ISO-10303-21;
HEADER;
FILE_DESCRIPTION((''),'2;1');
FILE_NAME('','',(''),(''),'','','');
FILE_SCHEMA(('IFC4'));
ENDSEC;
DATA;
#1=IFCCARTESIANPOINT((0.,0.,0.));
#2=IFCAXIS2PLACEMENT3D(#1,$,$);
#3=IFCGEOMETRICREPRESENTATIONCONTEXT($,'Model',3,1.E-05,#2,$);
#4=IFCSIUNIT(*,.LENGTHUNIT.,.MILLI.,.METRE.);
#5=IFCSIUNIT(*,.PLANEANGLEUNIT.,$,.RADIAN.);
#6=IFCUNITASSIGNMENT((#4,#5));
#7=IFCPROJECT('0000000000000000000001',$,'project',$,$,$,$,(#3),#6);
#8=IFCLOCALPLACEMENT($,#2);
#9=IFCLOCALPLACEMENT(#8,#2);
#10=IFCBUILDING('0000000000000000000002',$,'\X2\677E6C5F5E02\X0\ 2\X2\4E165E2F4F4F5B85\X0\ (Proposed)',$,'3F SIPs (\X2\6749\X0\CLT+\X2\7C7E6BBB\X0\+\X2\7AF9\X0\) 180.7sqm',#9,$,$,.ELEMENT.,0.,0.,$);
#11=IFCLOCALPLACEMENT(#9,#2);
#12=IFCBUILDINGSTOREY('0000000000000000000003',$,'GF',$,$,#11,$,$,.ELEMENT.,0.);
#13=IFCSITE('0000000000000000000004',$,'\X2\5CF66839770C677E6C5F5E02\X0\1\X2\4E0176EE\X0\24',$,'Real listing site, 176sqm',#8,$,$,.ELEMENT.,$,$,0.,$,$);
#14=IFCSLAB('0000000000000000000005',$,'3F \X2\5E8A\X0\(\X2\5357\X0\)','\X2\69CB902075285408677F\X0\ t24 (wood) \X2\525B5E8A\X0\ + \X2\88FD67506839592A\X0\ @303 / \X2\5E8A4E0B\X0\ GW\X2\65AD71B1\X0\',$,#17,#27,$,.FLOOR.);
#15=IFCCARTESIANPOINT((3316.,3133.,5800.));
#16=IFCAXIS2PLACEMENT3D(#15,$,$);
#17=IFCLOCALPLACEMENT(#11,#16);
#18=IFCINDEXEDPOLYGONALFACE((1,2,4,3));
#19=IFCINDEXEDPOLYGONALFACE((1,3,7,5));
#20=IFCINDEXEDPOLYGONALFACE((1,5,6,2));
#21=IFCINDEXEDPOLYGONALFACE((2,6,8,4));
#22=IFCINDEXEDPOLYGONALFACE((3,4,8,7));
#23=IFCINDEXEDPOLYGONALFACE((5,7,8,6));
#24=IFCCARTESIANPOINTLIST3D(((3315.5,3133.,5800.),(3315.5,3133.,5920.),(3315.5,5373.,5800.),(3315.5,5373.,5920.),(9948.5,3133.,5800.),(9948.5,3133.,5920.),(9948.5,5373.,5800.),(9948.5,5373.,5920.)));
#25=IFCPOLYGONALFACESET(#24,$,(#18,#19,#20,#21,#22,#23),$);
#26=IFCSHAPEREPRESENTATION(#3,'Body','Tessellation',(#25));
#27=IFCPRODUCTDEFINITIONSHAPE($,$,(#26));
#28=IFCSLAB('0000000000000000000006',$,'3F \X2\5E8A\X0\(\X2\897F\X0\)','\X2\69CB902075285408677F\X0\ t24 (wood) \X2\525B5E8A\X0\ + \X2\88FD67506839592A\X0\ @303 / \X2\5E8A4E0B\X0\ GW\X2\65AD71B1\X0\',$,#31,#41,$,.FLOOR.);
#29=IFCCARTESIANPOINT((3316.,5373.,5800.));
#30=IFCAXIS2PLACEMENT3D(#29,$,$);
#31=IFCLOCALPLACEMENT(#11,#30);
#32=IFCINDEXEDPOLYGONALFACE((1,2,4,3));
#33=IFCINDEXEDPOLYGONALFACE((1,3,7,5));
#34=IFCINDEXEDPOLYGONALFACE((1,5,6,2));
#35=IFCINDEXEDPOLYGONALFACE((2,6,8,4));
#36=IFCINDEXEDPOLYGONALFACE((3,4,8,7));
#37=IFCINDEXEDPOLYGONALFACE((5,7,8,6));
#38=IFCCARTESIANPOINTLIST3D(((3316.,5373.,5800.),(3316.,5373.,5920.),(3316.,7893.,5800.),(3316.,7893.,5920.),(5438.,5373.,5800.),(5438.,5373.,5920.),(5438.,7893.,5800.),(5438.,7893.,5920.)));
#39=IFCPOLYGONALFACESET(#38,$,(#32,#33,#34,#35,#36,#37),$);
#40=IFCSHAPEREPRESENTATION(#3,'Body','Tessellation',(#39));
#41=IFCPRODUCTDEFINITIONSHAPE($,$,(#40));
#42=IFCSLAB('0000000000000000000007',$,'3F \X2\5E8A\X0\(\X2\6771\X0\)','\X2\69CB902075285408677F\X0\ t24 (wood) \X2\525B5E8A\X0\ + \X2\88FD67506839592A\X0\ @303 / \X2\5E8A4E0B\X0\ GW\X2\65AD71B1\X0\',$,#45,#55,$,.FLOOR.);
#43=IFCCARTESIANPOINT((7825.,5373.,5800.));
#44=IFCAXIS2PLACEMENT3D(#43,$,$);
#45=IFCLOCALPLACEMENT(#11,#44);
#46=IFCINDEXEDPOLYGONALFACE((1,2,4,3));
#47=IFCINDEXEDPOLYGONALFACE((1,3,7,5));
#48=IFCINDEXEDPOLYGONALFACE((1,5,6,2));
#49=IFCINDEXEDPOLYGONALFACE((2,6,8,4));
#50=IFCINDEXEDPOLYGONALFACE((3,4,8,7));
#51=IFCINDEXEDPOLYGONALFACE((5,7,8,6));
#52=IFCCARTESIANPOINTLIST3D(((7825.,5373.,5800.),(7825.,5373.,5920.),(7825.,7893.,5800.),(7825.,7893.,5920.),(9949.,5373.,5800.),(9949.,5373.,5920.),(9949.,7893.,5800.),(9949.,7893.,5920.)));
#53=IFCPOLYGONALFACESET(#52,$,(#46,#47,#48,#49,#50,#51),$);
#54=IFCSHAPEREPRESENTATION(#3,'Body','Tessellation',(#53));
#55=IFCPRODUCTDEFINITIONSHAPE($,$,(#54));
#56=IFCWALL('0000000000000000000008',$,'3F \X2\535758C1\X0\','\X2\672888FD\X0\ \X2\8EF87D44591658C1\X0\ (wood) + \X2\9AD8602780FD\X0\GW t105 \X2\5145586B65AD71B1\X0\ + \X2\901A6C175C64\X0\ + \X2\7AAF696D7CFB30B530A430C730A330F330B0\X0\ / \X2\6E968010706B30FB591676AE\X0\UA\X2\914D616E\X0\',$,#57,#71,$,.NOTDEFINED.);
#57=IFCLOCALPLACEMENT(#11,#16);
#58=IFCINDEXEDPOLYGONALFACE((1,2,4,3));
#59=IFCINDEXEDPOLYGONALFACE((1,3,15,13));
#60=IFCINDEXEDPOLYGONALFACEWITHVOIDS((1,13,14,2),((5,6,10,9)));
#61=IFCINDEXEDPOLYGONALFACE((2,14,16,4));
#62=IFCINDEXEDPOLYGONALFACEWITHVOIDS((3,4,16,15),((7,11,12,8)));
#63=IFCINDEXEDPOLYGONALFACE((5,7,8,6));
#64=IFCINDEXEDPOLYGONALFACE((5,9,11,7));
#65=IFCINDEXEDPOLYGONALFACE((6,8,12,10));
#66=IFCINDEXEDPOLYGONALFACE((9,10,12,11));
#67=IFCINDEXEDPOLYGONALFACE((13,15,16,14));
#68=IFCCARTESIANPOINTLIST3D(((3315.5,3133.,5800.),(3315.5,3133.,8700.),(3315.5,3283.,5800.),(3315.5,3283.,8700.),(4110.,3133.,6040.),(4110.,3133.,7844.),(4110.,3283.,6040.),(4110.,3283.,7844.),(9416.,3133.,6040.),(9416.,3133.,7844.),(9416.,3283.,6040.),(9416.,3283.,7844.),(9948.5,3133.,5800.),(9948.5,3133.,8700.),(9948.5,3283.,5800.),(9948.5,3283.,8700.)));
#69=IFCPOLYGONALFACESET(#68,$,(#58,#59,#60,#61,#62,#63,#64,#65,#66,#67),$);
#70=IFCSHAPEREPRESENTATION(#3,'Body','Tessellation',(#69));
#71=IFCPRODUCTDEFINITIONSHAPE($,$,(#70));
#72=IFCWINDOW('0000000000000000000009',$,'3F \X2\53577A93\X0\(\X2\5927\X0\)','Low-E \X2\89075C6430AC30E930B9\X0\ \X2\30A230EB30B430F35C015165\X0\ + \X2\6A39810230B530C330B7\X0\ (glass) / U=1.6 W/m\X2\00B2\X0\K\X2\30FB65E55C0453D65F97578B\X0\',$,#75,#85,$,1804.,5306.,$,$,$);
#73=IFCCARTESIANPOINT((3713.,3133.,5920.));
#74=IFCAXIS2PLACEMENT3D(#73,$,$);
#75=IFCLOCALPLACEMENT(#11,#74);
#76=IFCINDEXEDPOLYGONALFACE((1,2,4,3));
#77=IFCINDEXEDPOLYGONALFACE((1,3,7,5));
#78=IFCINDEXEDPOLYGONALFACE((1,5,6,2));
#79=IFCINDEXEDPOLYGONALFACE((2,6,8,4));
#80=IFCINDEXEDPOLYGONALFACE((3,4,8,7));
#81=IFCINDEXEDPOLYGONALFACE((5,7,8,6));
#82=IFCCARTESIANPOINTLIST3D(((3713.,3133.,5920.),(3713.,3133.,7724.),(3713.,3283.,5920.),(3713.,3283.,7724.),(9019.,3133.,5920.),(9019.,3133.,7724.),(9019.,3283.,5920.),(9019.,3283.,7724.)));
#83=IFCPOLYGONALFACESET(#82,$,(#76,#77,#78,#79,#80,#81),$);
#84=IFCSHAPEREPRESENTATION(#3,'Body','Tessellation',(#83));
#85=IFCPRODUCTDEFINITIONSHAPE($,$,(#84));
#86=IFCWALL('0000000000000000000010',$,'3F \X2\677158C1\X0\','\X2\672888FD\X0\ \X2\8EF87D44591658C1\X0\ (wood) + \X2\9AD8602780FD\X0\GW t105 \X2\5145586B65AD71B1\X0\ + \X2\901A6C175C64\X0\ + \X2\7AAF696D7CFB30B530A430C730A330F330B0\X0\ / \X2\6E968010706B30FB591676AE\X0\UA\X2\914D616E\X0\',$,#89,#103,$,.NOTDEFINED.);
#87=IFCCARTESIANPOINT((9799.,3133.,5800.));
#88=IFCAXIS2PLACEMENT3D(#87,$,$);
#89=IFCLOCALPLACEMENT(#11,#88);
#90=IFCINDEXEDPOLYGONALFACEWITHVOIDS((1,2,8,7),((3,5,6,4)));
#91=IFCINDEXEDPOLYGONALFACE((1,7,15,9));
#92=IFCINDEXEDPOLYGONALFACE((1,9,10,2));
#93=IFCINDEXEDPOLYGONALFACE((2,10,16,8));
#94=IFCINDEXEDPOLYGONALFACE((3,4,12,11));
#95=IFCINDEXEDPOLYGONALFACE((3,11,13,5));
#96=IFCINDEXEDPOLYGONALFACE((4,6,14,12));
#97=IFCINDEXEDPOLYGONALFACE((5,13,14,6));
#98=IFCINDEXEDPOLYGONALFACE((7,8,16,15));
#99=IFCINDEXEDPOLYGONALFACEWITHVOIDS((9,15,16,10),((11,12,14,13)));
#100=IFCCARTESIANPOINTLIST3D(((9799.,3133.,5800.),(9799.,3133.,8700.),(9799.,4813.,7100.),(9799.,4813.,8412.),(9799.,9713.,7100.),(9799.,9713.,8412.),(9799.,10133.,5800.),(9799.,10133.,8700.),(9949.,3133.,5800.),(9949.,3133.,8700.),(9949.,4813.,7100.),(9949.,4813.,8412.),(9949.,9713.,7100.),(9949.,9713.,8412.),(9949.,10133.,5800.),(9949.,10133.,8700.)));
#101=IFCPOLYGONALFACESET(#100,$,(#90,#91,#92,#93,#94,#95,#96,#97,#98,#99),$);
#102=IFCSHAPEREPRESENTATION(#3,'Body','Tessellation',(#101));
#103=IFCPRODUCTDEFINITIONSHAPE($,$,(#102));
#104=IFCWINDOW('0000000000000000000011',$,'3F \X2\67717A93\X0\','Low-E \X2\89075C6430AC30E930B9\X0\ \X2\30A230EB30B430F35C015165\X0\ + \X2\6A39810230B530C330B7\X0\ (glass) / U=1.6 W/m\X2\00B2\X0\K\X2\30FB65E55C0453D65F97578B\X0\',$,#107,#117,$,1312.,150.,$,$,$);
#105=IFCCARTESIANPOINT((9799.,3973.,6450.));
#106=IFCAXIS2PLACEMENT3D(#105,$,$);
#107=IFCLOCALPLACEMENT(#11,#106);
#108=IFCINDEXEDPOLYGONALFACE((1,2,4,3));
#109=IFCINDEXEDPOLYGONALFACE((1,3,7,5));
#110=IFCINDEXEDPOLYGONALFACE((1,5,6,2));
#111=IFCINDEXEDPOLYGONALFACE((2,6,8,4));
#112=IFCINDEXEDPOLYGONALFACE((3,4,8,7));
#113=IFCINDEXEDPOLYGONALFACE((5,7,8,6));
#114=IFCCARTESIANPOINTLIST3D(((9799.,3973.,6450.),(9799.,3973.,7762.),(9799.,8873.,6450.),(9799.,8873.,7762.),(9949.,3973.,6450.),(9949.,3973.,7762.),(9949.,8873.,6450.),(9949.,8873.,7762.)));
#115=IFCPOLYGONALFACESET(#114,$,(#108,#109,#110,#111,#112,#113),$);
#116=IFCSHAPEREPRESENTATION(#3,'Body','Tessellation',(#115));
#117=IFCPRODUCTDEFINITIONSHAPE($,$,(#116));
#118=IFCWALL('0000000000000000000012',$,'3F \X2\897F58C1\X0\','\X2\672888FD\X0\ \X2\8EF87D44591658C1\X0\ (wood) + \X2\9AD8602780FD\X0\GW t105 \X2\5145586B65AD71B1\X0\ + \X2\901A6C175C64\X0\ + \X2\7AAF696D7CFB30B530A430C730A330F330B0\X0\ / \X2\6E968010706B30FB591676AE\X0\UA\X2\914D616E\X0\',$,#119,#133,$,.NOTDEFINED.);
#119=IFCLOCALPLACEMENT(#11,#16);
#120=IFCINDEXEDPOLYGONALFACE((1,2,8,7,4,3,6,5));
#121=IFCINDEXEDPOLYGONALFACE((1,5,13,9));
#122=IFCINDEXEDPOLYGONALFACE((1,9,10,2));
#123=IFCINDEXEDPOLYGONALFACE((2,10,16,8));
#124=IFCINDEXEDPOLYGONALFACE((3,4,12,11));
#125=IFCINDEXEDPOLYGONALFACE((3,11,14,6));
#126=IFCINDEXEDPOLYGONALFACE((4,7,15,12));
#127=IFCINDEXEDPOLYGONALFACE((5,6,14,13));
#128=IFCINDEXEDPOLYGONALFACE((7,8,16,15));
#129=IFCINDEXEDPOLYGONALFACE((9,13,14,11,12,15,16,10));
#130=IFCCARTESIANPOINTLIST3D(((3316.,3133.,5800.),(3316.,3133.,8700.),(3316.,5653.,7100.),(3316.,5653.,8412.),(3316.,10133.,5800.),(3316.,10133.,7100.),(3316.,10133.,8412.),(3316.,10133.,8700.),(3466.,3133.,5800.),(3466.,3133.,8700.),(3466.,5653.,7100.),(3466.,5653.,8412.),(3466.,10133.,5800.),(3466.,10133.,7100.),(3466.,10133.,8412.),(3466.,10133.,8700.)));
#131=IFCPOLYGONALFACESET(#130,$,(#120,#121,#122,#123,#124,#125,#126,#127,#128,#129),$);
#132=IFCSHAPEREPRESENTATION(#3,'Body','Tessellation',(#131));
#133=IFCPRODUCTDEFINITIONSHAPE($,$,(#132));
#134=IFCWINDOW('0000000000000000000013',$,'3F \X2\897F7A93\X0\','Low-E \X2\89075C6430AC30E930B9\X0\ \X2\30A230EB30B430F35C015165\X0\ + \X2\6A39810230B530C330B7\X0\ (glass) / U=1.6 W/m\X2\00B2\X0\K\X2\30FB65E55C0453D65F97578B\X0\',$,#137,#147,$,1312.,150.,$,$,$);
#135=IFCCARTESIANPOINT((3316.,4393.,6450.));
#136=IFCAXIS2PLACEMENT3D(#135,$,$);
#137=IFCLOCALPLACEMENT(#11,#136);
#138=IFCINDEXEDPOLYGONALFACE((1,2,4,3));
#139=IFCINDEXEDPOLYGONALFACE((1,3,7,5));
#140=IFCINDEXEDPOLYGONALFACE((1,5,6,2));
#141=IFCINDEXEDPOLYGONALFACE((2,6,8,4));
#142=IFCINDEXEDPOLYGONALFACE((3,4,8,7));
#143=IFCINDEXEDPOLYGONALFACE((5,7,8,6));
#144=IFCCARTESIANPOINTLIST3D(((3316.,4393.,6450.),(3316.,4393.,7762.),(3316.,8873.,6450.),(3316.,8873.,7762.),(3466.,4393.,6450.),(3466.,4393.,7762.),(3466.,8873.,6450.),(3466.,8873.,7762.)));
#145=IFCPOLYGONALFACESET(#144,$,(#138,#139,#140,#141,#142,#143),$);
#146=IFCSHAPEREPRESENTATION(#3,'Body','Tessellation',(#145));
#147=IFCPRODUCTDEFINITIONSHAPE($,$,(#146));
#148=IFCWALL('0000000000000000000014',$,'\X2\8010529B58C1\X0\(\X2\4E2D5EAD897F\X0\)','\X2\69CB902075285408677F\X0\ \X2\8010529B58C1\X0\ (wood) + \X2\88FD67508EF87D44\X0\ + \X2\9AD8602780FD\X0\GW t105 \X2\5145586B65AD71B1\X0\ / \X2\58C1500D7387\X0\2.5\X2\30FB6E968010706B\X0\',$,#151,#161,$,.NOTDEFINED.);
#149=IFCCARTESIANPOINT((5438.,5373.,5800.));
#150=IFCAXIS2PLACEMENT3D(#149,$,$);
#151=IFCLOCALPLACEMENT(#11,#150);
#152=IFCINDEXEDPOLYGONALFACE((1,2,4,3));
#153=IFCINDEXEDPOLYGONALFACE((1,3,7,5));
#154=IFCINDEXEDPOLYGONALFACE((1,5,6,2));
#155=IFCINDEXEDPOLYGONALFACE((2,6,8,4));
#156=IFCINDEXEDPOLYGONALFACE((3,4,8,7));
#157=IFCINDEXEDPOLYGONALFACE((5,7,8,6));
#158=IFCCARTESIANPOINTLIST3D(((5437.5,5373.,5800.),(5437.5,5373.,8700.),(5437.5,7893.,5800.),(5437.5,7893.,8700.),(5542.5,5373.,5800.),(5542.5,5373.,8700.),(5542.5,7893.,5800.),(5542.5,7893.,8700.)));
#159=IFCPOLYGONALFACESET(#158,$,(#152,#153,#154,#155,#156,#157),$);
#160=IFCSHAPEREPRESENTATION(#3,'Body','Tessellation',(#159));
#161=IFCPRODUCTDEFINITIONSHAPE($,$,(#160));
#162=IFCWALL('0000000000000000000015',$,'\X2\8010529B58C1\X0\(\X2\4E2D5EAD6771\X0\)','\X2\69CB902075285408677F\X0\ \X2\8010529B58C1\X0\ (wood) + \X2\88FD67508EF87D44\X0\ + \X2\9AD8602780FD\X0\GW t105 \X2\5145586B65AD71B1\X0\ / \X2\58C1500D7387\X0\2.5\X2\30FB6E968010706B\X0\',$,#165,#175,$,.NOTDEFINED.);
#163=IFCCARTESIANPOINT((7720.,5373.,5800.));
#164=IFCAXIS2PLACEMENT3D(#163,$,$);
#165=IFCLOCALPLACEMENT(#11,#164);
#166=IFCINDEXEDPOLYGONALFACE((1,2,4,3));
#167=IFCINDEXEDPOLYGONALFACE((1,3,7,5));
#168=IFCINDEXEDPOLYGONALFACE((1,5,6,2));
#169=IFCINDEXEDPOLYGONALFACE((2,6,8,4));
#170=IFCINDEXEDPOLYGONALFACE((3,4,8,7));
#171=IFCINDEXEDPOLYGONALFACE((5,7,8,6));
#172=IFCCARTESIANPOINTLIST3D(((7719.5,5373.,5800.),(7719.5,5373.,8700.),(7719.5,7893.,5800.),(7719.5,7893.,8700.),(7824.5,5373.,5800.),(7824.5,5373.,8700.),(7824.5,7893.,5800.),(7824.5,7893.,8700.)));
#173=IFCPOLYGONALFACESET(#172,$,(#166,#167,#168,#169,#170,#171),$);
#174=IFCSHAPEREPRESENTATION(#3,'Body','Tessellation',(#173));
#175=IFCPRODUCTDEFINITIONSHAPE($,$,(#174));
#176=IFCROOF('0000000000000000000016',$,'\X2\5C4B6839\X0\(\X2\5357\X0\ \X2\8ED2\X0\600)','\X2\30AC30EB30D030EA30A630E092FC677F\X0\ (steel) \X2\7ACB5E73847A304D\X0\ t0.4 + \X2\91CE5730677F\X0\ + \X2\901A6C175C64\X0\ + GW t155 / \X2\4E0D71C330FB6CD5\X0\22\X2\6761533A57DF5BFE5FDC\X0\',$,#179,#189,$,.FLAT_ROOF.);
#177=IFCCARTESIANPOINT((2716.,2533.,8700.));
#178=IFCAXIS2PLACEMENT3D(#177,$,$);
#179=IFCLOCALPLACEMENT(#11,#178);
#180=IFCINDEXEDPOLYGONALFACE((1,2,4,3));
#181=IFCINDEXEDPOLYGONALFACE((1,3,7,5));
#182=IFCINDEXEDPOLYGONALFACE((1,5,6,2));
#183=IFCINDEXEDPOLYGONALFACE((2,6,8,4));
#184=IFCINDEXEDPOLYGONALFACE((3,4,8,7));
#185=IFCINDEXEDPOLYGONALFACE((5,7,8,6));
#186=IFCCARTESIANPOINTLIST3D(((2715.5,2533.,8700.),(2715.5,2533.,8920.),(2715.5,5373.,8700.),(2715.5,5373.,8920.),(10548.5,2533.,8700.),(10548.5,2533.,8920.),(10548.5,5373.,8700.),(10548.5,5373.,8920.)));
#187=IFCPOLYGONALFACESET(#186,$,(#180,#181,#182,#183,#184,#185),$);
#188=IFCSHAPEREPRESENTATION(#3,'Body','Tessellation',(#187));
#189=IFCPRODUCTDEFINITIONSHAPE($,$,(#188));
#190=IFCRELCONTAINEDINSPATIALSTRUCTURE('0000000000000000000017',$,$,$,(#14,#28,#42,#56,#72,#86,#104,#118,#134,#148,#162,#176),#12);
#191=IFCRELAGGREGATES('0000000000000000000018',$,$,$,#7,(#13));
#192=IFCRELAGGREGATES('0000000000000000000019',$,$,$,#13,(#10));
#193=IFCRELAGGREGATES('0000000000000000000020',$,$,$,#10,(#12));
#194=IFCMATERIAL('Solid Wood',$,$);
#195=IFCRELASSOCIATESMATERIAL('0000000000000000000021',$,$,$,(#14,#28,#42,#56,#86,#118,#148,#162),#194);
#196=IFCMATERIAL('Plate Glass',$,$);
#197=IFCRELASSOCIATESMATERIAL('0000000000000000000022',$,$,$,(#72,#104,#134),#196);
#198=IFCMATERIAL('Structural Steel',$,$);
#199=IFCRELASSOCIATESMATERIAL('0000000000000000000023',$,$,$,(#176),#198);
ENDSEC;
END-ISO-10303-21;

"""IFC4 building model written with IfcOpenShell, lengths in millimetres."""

from ifc_helpers import new_model, si_unit, frame, frame_2d, origin, place, context, project, spatial, rectangle, extrude, material, element, fill, save


model = new_model("IFC4")

# Units and contexts
model_context = context("Model", 3, precision=1e-05, world=origin())
ifc_project = project(units=[si_unit("LENGTHUNIT", "METRE", prefix="MILLI"), si_unit("PLANEANGLEUNIT", "RADIAN")], contexts=[model_context])

# Site, building, storey
site_placement = place(None, origin())
site = spatial("IfcSite", under=ifc_project, at=site_placement, Name="島根県松江市1丁目24", ObjectType="Real listing site, 176sqm", CompositionType="ELEMENT", RefElevation=0.0)
building_placement = place(site_placement, origin())
building = spatial("IfcBuilding", under=site, at=building_placement, Name="松江市 2世帯住宅 (Proposed)", ObjectType="3F SIPs (杉CLT+籾殻+竹) 180.7sqm", CompositionType="ELEMENT", ElevationOfRefHeight=0.0, ElevationOfTerrain=0.0)
storey_placement = place(building_placement, origin())
storey = spatial("IfcBuildingStorey", under=building, at=storey_placement, Name="GF", CompositionType="ELEMENT", Elevation=0.0)

# Slabs
ifc_material_1 = material(Name="Solid Wood")
slab_1_placement = place(storey_placement, frame((3316.0, 3133.0, 5800.0)))
element("IfcSlab", 1, at=slab_1_placement, inside=storey, material=ifc_material_1, Name="3F 床(南)", Description="構造用合板 t24 (wood) 剛床 + 製材根太 @303 / 床下 GW断熱", PredefinedType="FLOOR", context=model_context, shape_type="SweptSolid", body=[
    extrude(rectangle(XDim=6633.0, YDim=2240.0, at=frame_2d((3316.0, 1120.0))), frame((3316.0, 3133.0, 5800.0)), (0.0, 0.0, 1.0), 120.0),
])
slab_2_placement = place(storey_placement, frame((3316.0, 5373.0, 5800.0)))
element("IfcSlab", 2, at=slab_2_placement, inside=storey, material=ifc_material_1, Name="3F 床(西)", Description="構造用合板 t24 (wood) 剛床 + 製材根太 @303 / 床下 GW断熱", PredefinedType="FLOOR", context=model_context, shape_type="SweptSolid", body=[
    extrude(rectangle(XDim=2122.0, YDim=2520.0, at=frame_2d((1061.0, 1260.0))), frame((3316.0, 5373.0, 5800.0)), (0.0, 0.0, 1.0), 120.0),
])
slab_3_placement = place(storey_placement, frame((7825.0, 5373.0, 5800.0)))
element("IfcSlab", 3, at=slab_3_placement, inside=storey, material=ifc_material_1, Name="3F 床(東)", Description="構造用合板 t24 (wood) 剛床 + 製材根太 @303 / 床下 GW断熱", PredefinedType="FLOOR", context=model_context, shape_type="SweptSolid", body=[
    extrude(rectangle(XDim=2124.0, YDim=2520.0, at=frame_2d((1062.0, 1260.0))), frame((7825.0, 5373.0, 5800.0)), (0.0, 0.0, 1.0), 120.0),
])

# Walls, openings, windows
wall_1_placement = place(storey_placement, frame((3316.0, 3133.0, 5800.0)))
wall_1 = element("IfcWall", 4, at=wall_1_placement, inside=storey, material=ifc_material_1, Name="3F 南壁", Description="木製 軸組外壁 (wood) + 高性能GW t105 充填断熱 + 通気層 + 窯業系サイディング / 準耐火・外皮UA配慮", PredefinedType="NOTDEFINED", context=model_context, shape_type="SweptSolid", body=[
    extrude(rectangle(XDim=6633.0, YDim=150.0, at=frame_2d((3316.0, 75.0))), frame((3316.0, 3133.0, 5800.0)), (0.0, 0.0, 1.0), 2900.0),
])
opening_1_placement = place(storey_placement, frame((3713.0, 3133.0, 5920.0)))
opening_1 = element("IfcOpeningElement", 5, at=opening_1_placement, cuts=wall_1, PredefinedType="NOTDEFINED", context=model_context, shape_type="SweptSolid", body=[
    extrude(rectangle(XDim=5306.0, YDim=150.0, at=frame_2d((2653.0, 75.0))), frame((3713.0, 3133.0, 5920.0)), (0.0, 0.0, 1.0), 1804.0),
])
ifc_material_2 = material(Name="Plate Glass")
window_1_placement = place(storey_placement, frame((3713.0, 3133.0, 5920.0)))
window_1 = element("IfcWindow", 6, at=window_1_placement, inside=storey, material=ifc_material_2, Name="3F 南窓(大)", Description="Low-E 複層ガラス アルゴン封入 + 樹脂サッシ (glass) / U=1.6 W/m²K・日射取得型", OverallHeight=1804.0, OverallWidth=5306.0, context=model_context, shape_type="SweptSolid", body=[
    extrude(rectangle(XDim=5306.0, YDim=150.0, at=frame_2d((2653.0, 75.0))), frame((3713.0, 3133.0, 5920.0)), (0.0, 0.0, 1.0), 1804.0),
])
fill(opening_1, window_1)
wall_2_placement = place(storey_placement, frame((9799.0, 3133.0, 5800.0)))
wall_2 = element("IfcWall", 7, at=wall_2_placement, inside=storey, material=ifc_material_1, Name="3F 東壁", Description="木製 軸組外壁 (wood) + 高性能GW t105 充填断熱 + 通気層 + 窯業系サイディング / 準耐火・外皮UA配慮", PredefinedType="NOTDEFINED", context=model_context, shape_type="SweptSolid", body=[
    extrude(rectangle(XDim=150.0, YDim=7000.0, at=frame_2d((75.0, 3500.0))), frame((9799.0, 3133.0, 5800.0)), (0.0, 0.0, 1.0), 2900.0),
])
opening_2_placement = place(storey_placement, frame((9799.0, 3973.0, 6450.0)))
opening_2 = element("IfcOpeningElement", 8, at=opening_2_placement, cuts=wall_2, PredefinedType="NOTDEFINED", context=model_context, shape_type="SweptSolid", body=[
    extrude(rectangle(XDim=150.0, YDim=4900.0, at=frame_2d((75.0, 2450.0))), frame((9799.0, 3973.0, 6450.0)), (0.0, 0.0, 1.0), 1312.0),
])
window_2_placement = place(storey_placement, frame((9799.0, 3973.0, 6450.0)))
window_2 = element("IfcWindow", 9, at=window_2_placement, inside=storey, material=ifc_material_2, Name="3F 東窓", Description="Low-E 複層ガラス アルゴン封入 + 樹脂サッシ (glass) / U=1.6 W/m²K・日射取得型", OverallHeight=1312.0, OverallWidth=150.0, context=model_context, shape_type="SweptSolid", body=[
    extrude(rectangle(XDim=150.0, YDim=4900.0, at=frame_2d((75.0, 2450.0))), frame((9799.0, 3973.0, 6450.0)), (0.0, 0.0, 1.0), 1312.0),
])
fill(opening_2, window_2)
wall_3_placement = place(storey_placement, frame((3316.0, 3133.0, 5800.0)))
wall_3 = element("IfcWall", 10, at=wall_3_placement, inside=storey, material=ifc_material_1, Name="3F 西壁", Description="木製 軸組外壁 (wood) + 高性能GW t105 充填断熱 + 通気層 + 窯業系サイディング / 準耐火・外皮UA配慮", PredefinedType="NOTDEFINED", context=model_context, shape_type="SweptSolid", body=[
    extrude(rectangle(XDim=150.0, YDim=7000.0, at=frame_2d((75.0, 3500.0))), frame((3316.0, 3133.0, 5800.0)), (0.0, 0.0, 1.0), 2900.0),
])
opening_3_placement = place(storey_placement, frame((3316.0, 4393.0, 6450.0)))
opening_3 = element("IfcOpeningElement", 11, at=opening_3_placement, cuts=wall_3, PredefinedType="NOTDEFINED", context=model_context, shape_type="SweptSolid", body=[
    extrude(rectangle(XDim=150.0, YDim=4480.0, at=frame_2d((75.0, 2240.0))), frame((3316.0, 4393.0, 6450.0)), (0.0, 0.0, 1.0), 1312.0),
])
window_3_placement = place(storey_placement, frame((3316.0, 4393.0, 6450.0)))
window_3 = element("IfcWindow", 12, at=window_3_placement, inside=storey, material=ifc_material_2, Name="3F 西窓", Description="Low-E 複層ガラス アルゴン封入 + 樹脂サッシ (glass) / U=1.6 W/m²K・日射取得型", OverallHeight=1312.0, OverallWidth=150.0, context=model_context, shape_type="SweptSolid", body=[
    extrude(rectangle(XDim=150.0, YDim=4480.0, at=frame_2d((75.0, 2240.0))), frame((3316.0, 4393.0, 6450.0)), (0.0, 0.0, 1.0), 1312.0),
])
fill(opening_3, window_3)

# Walls
wall_4_placement = place(storey_placement, frame((5438.0, 5373.0, 5800.0)))
element("IfcWall", 13, at=wall_4_placement, inside=storey, material=ifc_material_1, Name="耐力壁(中庭西)", Description="構造用合板 耐力壁 (wood) + 製材軸組 + 高性能GW t105 充填断熱 / 壁倍率2.5・準耐火", PredefinedType="NOTDEFINED", context=model_context, shape_type="SweptSolid", body=[
    extrude(rectangle(XDim=105.0, YDim=2520.0, at=frame_2d((52.0, 1260.0))), frame((5438.0, 5373.0, 5800.0)), (0.0, 0.0, 1.0), 2900.0),
])
wall_5_placement = place(storey_placement, frame((7720.0, 5373.0, 5800.0)))
element("IfcWall", 14, at=wall_5_placement, inside=storey, material=ifc_material_1, Name="耐力壁(中庭東)", Description="構造用合板 耐力壁 (wood) + 製材軸組 + 高性能GW t105 充填断熱 / 壁倍率2.5・準耐火", PredefinedType="NOTDEFINED", context=model_context, shape_type="SweptSolid", body=[
    extrude(rectangle(XDim=105.0, YDim=2520.0, at=frame_2d((52.0, 1260.0))), frame((7720.0, 5373.0, 5800.0)), (0.0, 0.0, 1.0), 2900.0),
])

# Roof
ifc_material_3 = material(Name="Structural Steel")
roof_1_placement = place(storey_placement, frame((2716.0, 2533.0, 8700.0)))
element("IfcRoof", 15, at=roof_1_placement, inside=storey, material=ifc_material_3, Name="屋根(南 軒600)", Description="ガルバリウム鋼板 (steel) 立平葺き t0.4 + 野地板 + 通気層 + GW t155 / 不燃・法22条区域対応", PredefinedType="FLAT_ROOF", context=model_context, shape_type="SweptSolid", body=[
    extrude(rectangle(XDim=7833.0, YDim=2840.0, at=frame_2d((3916.0, 1420.0))), frame((2716.0, 2533.0, 8700.0)), (0.0, 0.0, 1.0), 220.0),
])

save(model, "model.ifc")
